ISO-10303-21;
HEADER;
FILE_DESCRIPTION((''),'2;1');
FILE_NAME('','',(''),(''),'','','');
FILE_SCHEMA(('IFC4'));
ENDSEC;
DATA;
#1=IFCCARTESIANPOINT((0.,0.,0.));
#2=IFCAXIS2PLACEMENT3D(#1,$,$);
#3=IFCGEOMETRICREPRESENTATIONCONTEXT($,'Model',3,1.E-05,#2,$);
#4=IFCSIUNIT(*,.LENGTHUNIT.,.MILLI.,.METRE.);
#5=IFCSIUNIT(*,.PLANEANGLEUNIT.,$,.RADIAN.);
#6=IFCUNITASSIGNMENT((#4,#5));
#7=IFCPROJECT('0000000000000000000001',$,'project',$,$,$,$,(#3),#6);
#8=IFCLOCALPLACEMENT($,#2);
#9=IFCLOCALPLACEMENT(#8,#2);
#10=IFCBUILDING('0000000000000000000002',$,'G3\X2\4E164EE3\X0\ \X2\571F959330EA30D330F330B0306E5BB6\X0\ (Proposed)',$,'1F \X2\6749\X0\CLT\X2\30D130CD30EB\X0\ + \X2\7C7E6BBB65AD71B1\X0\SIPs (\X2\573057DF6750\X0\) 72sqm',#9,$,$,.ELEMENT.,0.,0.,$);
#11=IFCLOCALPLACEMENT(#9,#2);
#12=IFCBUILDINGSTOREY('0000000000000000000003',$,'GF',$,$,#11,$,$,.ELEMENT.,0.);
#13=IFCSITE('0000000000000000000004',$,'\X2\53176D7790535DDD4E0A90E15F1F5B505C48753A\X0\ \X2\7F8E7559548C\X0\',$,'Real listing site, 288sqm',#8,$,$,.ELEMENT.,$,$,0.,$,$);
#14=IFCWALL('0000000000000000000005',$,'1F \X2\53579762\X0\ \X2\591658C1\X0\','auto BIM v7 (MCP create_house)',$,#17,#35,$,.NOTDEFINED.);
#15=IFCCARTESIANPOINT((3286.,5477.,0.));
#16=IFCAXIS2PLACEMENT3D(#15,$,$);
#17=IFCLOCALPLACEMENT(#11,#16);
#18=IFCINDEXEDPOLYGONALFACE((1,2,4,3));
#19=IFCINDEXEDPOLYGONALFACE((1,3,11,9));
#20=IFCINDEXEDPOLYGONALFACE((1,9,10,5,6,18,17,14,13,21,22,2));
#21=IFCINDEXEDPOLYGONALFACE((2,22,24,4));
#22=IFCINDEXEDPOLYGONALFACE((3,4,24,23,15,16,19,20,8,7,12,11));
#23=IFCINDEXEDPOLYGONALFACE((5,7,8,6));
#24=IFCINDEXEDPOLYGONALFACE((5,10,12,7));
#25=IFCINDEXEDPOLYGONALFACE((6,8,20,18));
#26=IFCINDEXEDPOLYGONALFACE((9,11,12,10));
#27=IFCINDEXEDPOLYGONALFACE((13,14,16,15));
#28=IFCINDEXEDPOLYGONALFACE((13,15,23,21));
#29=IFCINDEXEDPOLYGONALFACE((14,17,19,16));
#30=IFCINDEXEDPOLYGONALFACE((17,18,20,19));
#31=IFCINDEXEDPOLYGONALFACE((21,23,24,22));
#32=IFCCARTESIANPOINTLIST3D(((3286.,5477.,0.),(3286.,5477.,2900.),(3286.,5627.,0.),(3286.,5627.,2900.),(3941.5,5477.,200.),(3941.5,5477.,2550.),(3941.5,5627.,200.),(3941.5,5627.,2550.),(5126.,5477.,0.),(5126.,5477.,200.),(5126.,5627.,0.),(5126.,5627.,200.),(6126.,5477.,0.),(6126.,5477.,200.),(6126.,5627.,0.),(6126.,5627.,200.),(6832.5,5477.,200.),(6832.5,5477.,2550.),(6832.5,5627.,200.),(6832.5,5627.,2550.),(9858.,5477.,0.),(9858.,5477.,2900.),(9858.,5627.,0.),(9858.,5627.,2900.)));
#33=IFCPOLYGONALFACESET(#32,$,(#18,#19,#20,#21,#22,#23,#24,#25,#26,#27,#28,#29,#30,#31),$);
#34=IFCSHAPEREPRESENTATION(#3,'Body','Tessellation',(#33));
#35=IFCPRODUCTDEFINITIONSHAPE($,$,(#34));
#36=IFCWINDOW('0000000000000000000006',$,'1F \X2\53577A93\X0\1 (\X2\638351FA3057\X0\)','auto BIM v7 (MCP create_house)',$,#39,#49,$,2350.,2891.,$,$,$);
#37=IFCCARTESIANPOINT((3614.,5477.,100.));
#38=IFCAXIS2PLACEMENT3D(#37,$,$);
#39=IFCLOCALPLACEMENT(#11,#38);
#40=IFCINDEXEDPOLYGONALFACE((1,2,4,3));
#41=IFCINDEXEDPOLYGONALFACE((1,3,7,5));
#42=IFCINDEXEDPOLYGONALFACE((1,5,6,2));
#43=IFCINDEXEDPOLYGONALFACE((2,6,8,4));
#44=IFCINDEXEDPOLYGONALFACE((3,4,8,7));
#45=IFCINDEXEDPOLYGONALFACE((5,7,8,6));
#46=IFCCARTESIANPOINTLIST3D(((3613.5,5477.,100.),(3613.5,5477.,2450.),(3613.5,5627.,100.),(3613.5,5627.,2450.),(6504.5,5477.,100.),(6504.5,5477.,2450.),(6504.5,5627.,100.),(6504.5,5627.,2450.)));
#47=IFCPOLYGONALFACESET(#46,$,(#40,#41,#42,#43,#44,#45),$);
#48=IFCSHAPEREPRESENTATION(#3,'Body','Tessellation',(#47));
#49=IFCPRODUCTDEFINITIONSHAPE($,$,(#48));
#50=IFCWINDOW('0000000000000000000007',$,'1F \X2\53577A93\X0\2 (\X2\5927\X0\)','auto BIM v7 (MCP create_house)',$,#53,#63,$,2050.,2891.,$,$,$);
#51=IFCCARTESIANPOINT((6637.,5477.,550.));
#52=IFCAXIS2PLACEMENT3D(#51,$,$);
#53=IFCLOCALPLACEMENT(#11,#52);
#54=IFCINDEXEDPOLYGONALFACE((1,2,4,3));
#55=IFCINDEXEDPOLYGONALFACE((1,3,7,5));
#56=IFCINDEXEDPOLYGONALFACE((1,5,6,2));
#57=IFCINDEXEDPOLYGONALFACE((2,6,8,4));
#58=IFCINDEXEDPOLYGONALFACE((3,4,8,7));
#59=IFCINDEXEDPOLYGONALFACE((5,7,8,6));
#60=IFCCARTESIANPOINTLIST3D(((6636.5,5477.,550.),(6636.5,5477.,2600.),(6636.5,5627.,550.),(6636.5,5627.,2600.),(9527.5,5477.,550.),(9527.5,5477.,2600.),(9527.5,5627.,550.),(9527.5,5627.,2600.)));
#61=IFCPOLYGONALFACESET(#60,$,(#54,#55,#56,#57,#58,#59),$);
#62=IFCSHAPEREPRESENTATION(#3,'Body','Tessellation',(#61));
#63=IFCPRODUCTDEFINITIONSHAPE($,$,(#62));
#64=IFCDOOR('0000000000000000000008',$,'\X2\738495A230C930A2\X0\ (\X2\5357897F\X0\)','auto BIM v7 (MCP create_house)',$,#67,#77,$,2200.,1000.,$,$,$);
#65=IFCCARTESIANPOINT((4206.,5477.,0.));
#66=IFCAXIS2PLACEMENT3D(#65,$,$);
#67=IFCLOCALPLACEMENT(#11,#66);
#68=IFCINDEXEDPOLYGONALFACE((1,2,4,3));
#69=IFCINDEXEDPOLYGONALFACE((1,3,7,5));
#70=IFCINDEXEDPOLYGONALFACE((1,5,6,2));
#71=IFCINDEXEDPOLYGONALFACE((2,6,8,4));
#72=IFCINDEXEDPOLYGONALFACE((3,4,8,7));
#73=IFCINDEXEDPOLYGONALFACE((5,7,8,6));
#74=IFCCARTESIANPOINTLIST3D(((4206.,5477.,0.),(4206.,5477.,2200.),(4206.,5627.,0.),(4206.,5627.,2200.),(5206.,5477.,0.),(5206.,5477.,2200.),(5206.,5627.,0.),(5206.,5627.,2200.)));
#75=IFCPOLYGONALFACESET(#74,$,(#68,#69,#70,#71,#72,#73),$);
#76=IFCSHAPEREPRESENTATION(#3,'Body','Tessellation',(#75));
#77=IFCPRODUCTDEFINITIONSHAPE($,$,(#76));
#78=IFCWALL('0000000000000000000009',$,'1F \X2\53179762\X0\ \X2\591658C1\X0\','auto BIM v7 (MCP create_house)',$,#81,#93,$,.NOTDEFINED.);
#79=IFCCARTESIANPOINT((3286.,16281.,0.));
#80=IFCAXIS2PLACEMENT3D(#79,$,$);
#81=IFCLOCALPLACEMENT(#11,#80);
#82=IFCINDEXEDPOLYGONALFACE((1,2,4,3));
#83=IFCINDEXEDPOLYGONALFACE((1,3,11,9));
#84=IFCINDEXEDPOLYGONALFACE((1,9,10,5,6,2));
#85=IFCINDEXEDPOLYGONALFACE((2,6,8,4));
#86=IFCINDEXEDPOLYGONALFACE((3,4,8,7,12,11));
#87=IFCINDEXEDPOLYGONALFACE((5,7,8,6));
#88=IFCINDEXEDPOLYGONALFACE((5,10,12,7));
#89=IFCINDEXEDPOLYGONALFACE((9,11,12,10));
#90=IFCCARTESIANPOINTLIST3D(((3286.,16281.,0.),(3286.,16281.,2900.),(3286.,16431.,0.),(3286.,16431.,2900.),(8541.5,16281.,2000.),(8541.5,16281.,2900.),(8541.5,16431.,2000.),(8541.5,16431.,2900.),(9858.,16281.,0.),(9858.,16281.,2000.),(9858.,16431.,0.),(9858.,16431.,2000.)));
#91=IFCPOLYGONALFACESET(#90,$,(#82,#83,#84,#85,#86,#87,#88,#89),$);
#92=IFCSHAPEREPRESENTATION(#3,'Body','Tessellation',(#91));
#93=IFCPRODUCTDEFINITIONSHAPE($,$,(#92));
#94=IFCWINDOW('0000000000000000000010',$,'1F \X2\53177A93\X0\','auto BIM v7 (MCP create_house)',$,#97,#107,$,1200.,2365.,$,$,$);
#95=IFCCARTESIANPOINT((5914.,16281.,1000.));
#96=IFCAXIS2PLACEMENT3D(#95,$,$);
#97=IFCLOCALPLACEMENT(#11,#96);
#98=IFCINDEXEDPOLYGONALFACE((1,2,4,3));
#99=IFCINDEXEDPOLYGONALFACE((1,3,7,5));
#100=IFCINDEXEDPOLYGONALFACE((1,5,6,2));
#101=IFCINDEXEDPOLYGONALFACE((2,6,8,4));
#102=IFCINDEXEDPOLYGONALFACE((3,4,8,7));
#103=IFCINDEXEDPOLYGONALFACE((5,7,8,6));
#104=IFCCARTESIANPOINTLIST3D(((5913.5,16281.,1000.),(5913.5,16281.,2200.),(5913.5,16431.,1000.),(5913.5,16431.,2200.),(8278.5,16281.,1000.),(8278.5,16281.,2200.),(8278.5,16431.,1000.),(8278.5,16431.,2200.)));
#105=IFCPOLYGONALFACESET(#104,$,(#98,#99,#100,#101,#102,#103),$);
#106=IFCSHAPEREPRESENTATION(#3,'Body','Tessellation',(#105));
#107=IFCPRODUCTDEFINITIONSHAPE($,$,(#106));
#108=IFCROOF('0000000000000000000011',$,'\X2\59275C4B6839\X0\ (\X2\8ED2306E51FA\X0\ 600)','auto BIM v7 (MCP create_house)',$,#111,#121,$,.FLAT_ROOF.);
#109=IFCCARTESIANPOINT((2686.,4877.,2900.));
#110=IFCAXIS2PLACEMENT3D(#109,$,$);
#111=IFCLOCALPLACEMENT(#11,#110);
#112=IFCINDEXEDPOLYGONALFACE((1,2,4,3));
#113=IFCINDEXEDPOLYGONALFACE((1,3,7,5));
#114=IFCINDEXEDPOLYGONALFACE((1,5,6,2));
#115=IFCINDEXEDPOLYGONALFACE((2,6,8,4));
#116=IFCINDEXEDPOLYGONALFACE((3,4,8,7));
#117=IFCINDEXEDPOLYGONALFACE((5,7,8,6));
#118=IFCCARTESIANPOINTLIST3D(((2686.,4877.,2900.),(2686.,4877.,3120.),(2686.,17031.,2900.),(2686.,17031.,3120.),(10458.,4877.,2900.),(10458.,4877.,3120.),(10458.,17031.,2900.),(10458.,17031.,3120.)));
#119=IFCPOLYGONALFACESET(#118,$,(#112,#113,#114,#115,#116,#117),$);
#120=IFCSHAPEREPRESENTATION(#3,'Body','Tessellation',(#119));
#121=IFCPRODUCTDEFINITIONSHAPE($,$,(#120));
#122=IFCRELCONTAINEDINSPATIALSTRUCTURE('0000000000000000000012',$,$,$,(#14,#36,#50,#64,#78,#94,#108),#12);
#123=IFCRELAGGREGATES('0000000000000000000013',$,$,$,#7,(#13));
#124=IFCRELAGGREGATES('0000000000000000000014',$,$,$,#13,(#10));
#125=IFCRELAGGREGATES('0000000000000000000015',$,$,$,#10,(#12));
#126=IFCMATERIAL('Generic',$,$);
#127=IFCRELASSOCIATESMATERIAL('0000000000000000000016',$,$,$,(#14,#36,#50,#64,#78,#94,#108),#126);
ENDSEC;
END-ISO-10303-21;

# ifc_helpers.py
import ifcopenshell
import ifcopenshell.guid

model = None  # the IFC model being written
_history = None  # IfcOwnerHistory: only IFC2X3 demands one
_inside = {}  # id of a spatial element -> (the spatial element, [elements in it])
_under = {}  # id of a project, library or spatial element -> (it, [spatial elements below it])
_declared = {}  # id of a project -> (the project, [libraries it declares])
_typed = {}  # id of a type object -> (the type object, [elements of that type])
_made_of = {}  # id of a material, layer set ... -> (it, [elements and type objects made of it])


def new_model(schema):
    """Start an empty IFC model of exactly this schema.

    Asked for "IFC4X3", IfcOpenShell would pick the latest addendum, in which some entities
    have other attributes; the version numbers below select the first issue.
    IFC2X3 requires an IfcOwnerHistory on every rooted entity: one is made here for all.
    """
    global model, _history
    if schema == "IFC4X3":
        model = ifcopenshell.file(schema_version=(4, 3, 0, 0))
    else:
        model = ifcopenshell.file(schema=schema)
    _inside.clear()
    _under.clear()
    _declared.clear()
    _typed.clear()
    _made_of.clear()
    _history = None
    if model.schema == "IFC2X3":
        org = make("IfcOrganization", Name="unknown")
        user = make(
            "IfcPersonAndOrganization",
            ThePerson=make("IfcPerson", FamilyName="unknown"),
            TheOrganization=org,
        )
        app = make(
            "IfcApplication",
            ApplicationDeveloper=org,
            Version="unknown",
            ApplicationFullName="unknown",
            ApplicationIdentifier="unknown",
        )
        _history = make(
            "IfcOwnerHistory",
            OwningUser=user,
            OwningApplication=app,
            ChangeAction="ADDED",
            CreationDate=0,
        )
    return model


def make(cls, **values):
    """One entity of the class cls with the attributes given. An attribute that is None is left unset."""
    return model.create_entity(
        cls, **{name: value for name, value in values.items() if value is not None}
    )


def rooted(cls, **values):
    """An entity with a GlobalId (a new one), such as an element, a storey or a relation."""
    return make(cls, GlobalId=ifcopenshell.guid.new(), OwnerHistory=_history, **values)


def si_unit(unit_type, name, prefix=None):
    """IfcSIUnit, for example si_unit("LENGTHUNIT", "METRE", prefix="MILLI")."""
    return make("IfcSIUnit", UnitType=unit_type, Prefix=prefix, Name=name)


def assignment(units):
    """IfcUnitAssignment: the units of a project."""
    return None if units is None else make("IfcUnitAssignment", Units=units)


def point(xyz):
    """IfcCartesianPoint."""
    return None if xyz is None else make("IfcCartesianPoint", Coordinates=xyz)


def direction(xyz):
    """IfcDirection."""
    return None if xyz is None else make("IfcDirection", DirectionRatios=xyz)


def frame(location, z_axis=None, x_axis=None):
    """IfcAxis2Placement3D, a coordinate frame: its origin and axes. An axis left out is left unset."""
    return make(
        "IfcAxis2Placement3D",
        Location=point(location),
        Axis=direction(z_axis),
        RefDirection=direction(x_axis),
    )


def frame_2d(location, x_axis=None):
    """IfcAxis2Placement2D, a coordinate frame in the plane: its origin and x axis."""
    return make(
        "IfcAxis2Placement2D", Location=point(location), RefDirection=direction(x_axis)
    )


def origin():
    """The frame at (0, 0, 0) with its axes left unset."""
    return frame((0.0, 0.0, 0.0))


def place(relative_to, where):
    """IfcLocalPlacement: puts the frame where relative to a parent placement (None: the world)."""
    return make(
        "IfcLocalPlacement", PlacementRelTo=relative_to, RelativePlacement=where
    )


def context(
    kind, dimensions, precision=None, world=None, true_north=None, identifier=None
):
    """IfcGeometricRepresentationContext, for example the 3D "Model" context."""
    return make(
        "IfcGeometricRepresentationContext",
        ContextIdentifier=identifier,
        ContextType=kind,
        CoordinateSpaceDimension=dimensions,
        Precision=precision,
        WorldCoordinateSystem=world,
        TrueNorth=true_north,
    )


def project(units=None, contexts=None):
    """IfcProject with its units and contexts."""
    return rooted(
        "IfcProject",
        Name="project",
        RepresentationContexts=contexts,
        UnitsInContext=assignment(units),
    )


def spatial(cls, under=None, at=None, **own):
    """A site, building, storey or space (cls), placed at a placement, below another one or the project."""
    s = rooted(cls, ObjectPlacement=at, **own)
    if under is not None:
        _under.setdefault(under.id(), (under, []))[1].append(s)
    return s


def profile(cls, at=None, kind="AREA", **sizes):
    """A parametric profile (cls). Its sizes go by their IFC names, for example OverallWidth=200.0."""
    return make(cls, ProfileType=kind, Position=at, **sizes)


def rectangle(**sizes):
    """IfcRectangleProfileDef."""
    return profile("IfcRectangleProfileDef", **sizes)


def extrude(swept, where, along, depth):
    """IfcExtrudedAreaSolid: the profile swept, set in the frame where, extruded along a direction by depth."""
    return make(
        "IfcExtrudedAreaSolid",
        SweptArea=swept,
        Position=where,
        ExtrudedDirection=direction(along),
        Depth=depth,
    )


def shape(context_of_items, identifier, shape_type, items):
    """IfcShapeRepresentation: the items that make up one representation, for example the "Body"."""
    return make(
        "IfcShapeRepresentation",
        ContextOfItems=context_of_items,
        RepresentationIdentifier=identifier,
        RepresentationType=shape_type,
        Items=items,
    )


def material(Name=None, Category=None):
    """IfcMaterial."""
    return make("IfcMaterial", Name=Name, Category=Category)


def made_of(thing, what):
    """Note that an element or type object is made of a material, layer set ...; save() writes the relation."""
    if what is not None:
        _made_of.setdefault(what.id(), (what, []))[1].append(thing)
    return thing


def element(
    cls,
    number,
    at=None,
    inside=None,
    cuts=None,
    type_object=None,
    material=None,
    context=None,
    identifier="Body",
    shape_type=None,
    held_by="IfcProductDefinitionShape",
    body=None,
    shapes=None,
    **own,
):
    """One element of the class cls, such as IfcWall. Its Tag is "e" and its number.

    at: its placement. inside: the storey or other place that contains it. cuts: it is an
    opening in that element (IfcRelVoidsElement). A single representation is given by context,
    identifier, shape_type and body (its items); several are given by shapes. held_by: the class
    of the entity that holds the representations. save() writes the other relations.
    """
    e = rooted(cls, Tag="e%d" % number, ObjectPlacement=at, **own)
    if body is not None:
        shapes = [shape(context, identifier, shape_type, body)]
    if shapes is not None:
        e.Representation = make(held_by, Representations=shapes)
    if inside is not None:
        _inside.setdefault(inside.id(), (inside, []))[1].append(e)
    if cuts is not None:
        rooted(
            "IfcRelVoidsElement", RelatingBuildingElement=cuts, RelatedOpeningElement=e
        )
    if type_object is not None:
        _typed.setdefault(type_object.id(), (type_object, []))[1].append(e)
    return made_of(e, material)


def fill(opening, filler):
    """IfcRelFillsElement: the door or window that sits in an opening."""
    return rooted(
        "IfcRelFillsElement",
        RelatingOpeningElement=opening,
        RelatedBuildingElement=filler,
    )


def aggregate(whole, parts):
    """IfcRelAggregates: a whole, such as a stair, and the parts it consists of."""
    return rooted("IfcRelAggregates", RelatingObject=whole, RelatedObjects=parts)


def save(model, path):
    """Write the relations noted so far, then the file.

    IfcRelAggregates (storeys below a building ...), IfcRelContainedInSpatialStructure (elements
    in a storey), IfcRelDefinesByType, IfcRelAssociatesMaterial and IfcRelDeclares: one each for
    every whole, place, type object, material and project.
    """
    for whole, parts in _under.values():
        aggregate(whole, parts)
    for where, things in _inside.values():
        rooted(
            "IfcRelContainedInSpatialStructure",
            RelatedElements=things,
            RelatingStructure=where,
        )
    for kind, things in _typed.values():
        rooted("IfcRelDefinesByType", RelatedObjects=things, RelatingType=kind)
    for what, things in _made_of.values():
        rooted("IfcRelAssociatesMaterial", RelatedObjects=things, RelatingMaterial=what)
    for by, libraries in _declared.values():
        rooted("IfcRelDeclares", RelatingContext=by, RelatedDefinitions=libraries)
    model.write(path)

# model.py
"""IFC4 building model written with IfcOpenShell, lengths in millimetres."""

from ifc_helpers import new_model, si_unit, frame, frame_2d, origin, place, context, project, spatial, rectangle, extrude, material, element, fill, save


model = new_model("IFC4")

# Units and contexts
model_context = context("Model", 3, precision=1e-05, world=origin())
ifc_project = project(units=[si_unit("LENGTHUNIT", "METRE", prefix="MILLI"), si_unit("PLANEANGLEUNIT", "RADIAN")], contexts=[model_context])

# Site, building, storey
site_placement = place(None, origin())
site = spatial("IfcSite", under=ifc_project, at=site_placement, Name="北海道川上郡弟子屈町 美留和", ObjectType="Real listing site, 288sqm", CompositionType="ELEMENT", RefElevation=0.0)
building_placement = place(site_placement, origin())
building = spatial("IfcBuilding", under=site, at=building_placement, Name="G3世代 土間リビングの家 (Proposed)", ObjectType="1F 杉CLTパネル + 籾殻断熱SIPs (地域材) 72sqm", CompositionType="ELEMENT", ElevationOfRefHeight=0.0, ElevationOfTerrain=0.0)
storey_placement = place(building_placement, origin())
storey = spatial("IfcBuildingStorey", under=building, at=storey_placement, Name="GF", CompositionType="ELEMENT", Elevation=0.0)

# Shared definitions
ifc_material = material(Name="Generic")

# Wall, openings, windows, door
wall_1_placement = place(storey_placement, frame((3286.0, 5477.0, 0.0)))
wall_1 = element("IfcWall", 1, at=wall_1_placement, inside=storey, material=ifc_material, Name="1F 南面 外壁", Description="auto BIM v7 (MCP create_house)", PredefinedType="NOTDEFINED", context=model_context, shape_type="SweptSolid", body=[
    extrude(rectangle(XDim=6572.0, YDim=150.0, at=frame_2d((3286.0, 75.0))), frame((3286.0, 5477.0, 0.0)), (0.0, 0.0, 1.0), 2900.0),
])
opening_1_placement = place(storey_placement, frame((3614.0, 5477.0, 100.0)))
opening_1 = element("IfcOpeningElement", 2, at=opening_1_placement, cuts=wall_1, PredefinedType="NOTDEFINED", context=model_context, shape_type="SweptSolid", body=[
    extrude(rectangle(XDim=2891.0, YDim=150.0, at=frame_2d((1445.0, 75.0))), frame((3614.0, 5477.0, 100.0)), (0.0, 0.0, 1.0), 2350.0),
])
opening_2_placement = place(storey_placement, frame((6637.0, 5477.0, 550.0)))
opening_2 = element("IfcOpeningElement", 3, at=opening_2_placement, cuts=wall_1, PredefinedType="NOTDEFINED", context=model_context, shape_type="SweptSolid", body=[
    extrude(rectangle(XDim=2891.0, YDim=150.0, at=frame_2d((1445.0, 75.0))), frame((6637.0, 5477.0, 550.0)), (0.0, 0.0, 1.0), 2050.0),
])
opening_3_placement = place(storey_placement, frame((4206.0, 5477.0, 0.0)))
opening_3 = element("IfcOpeningElement", 4, at=opening_3_placement, cuts=wall_1, PredefinedType="NOTDEFINED", context=model_context, shape_type="SweptSolid", body=[
    extrude(rectangle(XDim=1000.0, YDim=150.0, at=frame_2d((500.0, 75.0))), frame((4206.0, 5477.0, 0.0)), (0.0, 0.0, 1.0), 2200.0),
])
window_1_placement = place(storey_placement, frame((3614.0, 5477.0, 100.0)))
window_1 = element("IfcWindow", 5, at=window_1_placement, inside=storey, material=ifc_material, Name="1F 南窓1 (掃出し)", Description="auto BIM v7 (MCP create_house)", OverallHeight=2350.0, OverallWidth=2891.0, context=model_context, shape_type="SweptSolid", body=[
    extrude(rectangle(XDim=2891.0, YDim=150.0, at=frame_2d((1445.0, 75.0))), frame((3614.0, 5477.0, 100.0)), (0.0, 0.0, 1.0), 2350.0),
])
fill(opening_1, window_1)
window_2_placement = place(storey_placement, frame((6637.0, 5477.0, 550.0)))
window_2 = element("IfcWindow", 6, at=window_2_placement, inside=storey, material=ifc_material, Name="1F 南窓2 (大)", Description="auto BIM v7 (MCP create_house)", OverallHeight=2050.0, OverallWidth=2891.0, context=model_context, shape_type="SweptSolid", body=[
    extrude(rectangle(XDim=2891.0, YDim=150.0, at=frame_2d((1445.0, 75.0))), frame((6637.0, 5477.0, 550.0)), (0.0, 0.0, 1.0), 2050.0),
])
fill(opening_2, window_2)
door_placement = place(storey_placement, frame((4206.0, 5477.0, 0.0)))
door = element("IfcDoor", 7, at=door_placement, inside=storey, material=ifc_material, Name="玄関ドア (南西)", Description="auto BIM v7 (MCP create_house)", OverallHeight=2200.0, OverallWidth=1000.0, context=model_context, shape_type="SweptSolid", body=[
    extrude(rectangle(XDim=1000.0, YDim=150.0, at=frame_2d((500.0, 75.0))), frame((4206.0, 5477.0, 0.0)), (0.0, 0.0, 1.0), 2200.0),
])
fill(opening_3, door)

# Wall, opening, window
wall_2_placement = place(storey_placement, frame((3286.0, 16281.0, 0.0)))
wall_2 = element("IfcWall", 8, at=wall_2_placement, inside=storey, material=ifc_material, Name="1F 北面 外壁", Description="auto BIM v7 (MCP create_house)", PredefinedType="NOTDEFINED", context=model_context, shape_type="SweptSolid", body=[
    extrude(rectangle(XDim=6572.0, YDim=150.0, at=frame_2d((3286.0, 75.0))), frame((3286.0, 16281.0, 0.0)), (0.0, 0.0, 1.0), 2900.0),
])
opening_4_placement = place(storey_placement, frame((5914.0, 16281.0, 1000.0)))
opening_4 = element("IfcOpeningElement", 9, at=opening_4_placement, cuts=wall_2, PredefinedType="NOTDEFINED", context=model_context, shape_type="SweptSolid", body=[
    extrude(rectangle(XDim=2365.0, YDim=150.0, at=frame_2d((1182.0, 75.0))), frame((5914.0, 16281.0, 1000.0)), (0.0, 0.0, 1.0), 1200.0),
])
window_3_placement = place(storey_placement, frame((5914.0, 16281.0, 1000.0)))
window_3 = element("IfcWindow", 10, at=window_3_placement, inside=storey, material=ifc_material, Name="1F 北窓", Description="auto BIM v7 (MCP create_house)", OverallHeight=1200.0, OverallWidth=2365.0, context=model_context, shape_type="SweptSolid", body=[
    extrude(rectangle(XDim=2365.0, YDim=150.0, at=frame_2d((1182.0, 75.0))), frame((5914.0, 16281.0, 1000.0)), (0.0, 0.0, 1.0), 1200.0),
])
fill(opening_4, window_3)

# Roof
roof_placement = place(storey_placement, frame((2686.0, 4877.0, 2900.0)))
element("IfcRoof", 11, at=roof_placement, inside=storey, material=ifc_material, Name="大屋根 (軒の出 600)", Description="auto BIM v7 (MCP create_house)", PredefinedType="FLAT_ROOF", context=model_context, shape_type="SweptSolid", body=[
    extrude(rectangle(XDim=7772.0, YDim=12154.0, at=frame_2d((3886.0, 6077.0))), frame((2686.0, 4877.0, 2900.0)), (0.0, 0.0, 1.0), 220.0),
])

save(model, "model.ifc")
